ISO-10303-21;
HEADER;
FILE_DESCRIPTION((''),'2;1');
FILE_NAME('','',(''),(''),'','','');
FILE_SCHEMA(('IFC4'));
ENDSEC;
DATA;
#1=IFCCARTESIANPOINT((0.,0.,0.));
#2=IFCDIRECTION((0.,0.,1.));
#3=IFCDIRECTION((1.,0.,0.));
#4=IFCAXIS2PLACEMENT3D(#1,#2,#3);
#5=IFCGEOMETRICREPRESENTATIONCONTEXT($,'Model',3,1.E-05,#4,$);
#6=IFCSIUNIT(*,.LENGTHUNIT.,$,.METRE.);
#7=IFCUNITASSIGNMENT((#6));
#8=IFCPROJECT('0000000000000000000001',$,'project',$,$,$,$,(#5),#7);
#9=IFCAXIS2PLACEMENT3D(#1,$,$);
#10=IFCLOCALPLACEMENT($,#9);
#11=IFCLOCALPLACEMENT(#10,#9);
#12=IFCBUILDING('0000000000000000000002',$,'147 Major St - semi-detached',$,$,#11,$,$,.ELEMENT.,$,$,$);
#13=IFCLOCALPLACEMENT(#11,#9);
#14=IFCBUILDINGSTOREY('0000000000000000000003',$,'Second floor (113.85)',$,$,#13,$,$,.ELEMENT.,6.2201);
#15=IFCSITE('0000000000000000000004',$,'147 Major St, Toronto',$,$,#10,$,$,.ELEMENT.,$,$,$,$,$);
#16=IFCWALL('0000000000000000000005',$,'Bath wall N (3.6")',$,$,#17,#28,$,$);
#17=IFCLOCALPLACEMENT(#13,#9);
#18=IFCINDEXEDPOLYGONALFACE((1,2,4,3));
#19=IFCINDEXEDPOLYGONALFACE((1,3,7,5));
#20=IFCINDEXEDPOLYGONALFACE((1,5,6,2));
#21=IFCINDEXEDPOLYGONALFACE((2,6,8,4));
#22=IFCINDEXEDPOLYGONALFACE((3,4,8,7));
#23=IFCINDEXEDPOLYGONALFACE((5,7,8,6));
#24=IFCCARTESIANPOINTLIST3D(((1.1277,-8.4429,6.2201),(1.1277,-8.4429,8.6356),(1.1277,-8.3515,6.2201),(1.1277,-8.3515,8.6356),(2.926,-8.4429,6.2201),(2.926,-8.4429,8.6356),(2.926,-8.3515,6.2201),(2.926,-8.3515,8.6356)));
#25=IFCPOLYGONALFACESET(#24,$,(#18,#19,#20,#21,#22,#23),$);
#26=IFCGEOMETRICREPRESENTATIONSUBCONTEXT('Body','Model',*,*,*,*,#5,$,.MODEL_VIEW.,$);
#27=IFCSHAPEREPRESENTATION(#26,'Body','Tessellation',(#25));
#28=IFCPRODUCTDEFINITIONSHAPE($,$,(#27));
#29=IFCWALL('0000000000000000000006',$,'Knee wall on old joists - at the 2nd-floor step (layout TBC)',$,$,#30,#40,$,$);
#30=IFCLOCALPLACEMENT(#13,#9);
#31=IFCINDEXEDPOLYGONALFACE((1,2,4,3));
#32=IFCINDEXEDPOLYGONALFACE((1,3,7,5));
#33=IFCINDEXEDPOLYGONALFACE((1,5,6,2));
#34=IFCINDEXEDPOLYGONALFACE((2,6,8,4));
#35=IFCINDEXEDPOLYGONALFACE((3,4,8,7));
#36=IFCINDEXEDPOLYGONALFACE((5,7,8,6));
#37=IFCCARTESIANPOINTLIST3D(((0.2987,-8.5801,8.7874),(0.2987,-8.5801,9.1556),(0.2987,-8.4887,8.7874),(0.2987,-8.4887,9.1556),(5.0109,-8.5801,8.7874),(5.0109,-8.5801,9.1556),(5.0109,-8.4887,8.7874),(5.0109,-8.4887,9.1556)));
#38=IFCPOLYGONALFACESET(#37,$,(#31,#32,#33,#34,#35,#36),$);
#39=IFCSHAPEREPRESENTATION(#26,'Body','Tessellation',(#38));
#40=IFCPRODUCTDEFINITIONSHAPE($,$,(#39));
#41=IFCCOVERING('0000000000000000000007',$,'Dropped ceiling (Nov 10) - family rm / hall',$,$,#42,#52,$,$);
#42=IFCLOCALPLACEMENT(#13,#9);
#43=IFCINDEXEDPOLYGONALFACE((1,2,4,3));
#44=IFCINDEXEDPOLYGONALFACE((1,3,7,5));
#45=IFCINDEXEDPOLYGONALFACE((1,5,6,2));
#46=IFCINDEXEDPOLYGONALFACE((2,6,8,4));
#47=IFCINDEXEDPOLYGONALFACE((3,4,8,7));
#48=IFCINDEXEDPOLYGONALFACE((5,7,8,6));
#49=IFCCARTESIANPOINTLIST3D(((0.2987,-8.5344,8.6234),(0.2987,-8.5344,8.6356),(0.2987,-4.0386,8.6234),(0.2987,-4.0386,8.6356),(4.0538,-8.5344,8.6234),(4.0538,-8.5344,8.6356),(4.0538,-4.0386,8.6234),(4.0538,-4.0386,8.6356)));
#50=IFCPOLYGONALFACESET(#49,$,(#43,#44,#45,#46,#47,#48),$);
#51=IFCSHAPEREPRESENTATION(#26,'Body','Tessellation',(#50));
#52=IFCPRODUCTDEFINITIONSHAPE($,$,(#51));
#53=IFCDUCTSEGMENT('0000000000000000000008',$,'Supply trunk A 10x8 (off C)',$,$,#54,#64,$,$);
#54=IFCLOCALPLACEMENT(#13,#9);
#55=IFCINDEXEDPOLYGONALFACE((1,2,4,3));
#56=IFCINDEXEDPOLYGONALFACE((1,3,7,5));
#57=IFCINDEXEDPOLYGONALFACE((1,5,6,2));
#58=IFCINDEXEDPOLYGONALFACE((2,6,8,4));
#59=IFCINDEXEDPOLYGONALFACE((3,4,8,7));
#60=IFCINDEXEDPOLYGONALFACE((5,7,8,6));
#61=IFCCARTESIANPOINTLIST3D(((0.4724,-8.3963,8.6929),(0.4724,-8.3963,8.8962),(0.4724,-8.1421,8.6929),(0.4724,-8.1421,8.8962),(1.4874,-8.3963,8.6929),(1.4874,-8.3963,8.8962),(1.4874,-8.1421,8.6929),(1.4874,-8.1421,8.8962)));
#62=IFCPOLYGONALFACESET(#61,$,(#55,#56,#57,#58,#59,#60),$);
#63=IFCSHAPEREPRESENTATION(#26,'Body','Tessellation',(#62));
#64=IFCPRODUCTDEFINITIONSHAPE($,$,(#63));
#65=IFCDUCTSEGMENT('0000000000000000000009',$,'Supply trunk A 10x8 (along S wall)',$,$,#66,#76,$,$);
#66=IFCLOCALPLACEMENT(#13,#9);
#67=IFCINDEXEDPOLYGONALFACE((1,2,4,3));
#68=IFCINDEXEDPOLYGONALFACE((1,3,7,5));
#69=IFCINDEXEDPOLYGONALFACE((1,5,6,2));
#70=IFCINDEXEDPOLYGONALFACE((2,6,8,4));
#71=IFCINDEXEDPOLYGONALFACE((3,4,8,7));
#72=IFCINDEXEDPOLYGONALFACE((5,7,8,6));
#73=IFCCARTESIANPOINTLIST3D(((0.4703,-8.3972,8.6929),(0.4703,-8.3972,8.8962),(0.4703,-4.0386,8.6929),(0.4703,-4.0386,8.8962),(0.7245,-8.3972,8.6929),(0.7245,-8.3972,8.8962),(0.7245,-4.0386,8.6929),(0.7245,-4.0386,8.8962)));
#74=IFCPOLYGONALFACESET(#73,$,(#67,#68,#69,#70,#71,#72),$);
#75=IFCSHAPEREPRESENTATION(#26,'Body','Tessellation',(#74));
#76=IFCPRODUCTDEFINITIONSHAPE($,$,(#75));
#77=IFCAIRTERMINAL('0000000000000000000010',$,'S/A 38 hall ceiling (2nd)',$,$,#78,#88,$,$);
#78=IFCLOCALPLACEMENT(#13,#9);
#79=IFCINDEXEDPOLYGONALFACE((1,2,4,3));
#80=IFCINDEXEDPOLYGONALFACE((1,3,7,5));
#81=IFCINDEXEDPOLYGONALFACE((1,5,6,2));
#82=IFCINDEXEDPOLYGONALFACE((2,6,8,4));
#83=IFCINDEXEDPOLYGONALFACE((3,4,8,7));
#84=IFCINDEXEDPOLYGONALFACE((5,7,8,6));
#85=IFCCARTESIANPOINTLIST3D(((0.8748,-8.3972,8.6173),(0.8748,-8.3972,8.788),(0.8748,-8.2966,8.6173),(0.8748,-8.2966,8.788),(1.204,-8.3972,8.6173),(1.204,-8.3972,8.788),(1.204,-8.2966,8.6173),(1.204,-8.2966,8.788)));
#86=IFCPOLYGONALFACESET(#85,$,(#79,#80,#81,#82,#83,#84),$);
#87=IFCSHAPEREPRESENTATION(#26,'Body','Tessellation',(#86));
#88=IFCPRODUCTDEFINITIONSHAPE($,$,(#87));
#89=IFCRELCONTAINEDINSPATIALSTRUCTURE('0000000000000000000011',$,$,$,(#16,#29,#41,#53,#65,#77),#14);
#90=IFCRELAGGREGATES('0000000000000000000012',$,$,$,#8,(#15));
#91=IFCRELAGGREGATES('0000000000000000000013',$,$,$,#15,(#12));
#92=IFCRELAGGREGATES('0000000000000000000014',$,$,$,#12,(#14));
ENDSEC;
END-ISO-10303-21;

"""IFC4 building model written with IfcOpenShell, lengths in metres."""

from ifc_helpers import new_model, si_unit, frame, origin, origin_with_axes, place, context, subcontext, project, spatial, rectangle, extrude, element, save


model = new_model("IFC4")

# Units and contexts
model_context = context("Model", 3, precision=1e-05, world=origin_with_axes())
body_context = subcontext(model_context, "Body", "Model", "MODEL_VIEW")
ifc_project = project(units=[si_unit("LENGTHUNIT", "METRE")], contexts=[model_context])

# Site, building, storey
site_placement = place(None, origin())
site = spatial("IfcSite", under=ifc_project, at=site_placement, Name="147 Major St, Toronto", CompositionType="ELEMENT")
building_placement = place(site_placement, origin())
building = spatial("IfcBuilding", under=site, at=building_placement, Name="147 Major St - semi-detached", CompositionType="ELEMENT")
storey_placement = place(building_placement, origin())
storey = spatial("IfcBuildingStorey", under=building, at=storey_placement, Name="Second floor (113.85)", CompositionType="ELEMENT", Elevation=6.2201)

# Walls
wall_1_placement = place(storey_placement, frame((2.0269, -8.3972, 6.2201)))
element("IfcWall", 1, at=wall_1_placement, inside=storey, Name="Bath wall N (3.6\")", context=body_context, shape_type="SweptSolid", body=[
    extrude(rectangle(XDim=1.7983, YDim=0.0914), origin_with_axes(), (0.0, 0.0, 1.0), 2.4155),
])
wall_2_placement = place(storey_placement, frame((2.6548, -8.5344, 8.7874)))
element("IfcWall", 2, at=wall_2_placement, inside=storey, Name="Knee wall on old joists - at the 2nd-floor step (layout TBC)", context=body_context, shape_type="SweptSolid", body=[
    extrude(rectangle(XDim=4.7122, YDim=0.0914), origin_with_axes(), (0.0, 0.0, 1.0), 0.3682),
])

# Covering
for number, where, name in (
    (3, (2.1763, -6.2865, 8.6234), "Dropped ceiling (Nov 10) - family rm / hall"),
):
    element("IfcCovering", number, at=place(storey_placement, frame(where)), inside=storey, Name=name, context=body_context, shape_type="SweptSolid", body=[
        extrude(rectangle(XDim=3.7551, YDim=4.4958), origin_with_axes(), (0.0, 0.0, 1.0), 0.0122),
    ])

# Duct segments
duct_segment_1_placement = place(storey_placement, frame((0.9799, -8.2692, 8.6929)))
element("IfcDuctSegment", 4, at=duct_segment_1_placement, inside=storey, Name="Supply trunk A 10x8 (off C)", context=body_context, shape_type="SweptSolid", body=[
    extrude(rectangle(XDim=1.015, YDim=0.2542), origin_with_axes(), (0.0, 0.0, 1.0), 0.2033),
])
duct_segment_2_placement = place(storey_placement, frame((0.5974, -6.2179, 8.6929)))
element("IfcDuctSegment", 5, at=duct_segment_2_placement, inside=storey, Name="Supply trunk A 10x8 (along S wall)", context=body_context, shape_type="SweptSolid", body=[
    extrude(rectangle(XDim=0.2542, YDim=4.3586), origin_with_axes(), (0.0, 0.0, 1.0), 0.2033),
])

# Air terminal
air_terminal_placement = place(storey_placement, frame((1.0394, -8.3469, 8.6173)))
element("IfcAirTerminal", 6, at=air_terminal_placement, inside=storey, Name="S/A 38 hall ceiling (2nd)", context=body_context, shape_type="SweptSolid", body=[
    extrude(rectangle(XDim=0.3292, YDim=0.1006), origin_with_axes(), (0.0, 0.0, 1.0), 0.1707),
])

save(model, "model.ifc")
